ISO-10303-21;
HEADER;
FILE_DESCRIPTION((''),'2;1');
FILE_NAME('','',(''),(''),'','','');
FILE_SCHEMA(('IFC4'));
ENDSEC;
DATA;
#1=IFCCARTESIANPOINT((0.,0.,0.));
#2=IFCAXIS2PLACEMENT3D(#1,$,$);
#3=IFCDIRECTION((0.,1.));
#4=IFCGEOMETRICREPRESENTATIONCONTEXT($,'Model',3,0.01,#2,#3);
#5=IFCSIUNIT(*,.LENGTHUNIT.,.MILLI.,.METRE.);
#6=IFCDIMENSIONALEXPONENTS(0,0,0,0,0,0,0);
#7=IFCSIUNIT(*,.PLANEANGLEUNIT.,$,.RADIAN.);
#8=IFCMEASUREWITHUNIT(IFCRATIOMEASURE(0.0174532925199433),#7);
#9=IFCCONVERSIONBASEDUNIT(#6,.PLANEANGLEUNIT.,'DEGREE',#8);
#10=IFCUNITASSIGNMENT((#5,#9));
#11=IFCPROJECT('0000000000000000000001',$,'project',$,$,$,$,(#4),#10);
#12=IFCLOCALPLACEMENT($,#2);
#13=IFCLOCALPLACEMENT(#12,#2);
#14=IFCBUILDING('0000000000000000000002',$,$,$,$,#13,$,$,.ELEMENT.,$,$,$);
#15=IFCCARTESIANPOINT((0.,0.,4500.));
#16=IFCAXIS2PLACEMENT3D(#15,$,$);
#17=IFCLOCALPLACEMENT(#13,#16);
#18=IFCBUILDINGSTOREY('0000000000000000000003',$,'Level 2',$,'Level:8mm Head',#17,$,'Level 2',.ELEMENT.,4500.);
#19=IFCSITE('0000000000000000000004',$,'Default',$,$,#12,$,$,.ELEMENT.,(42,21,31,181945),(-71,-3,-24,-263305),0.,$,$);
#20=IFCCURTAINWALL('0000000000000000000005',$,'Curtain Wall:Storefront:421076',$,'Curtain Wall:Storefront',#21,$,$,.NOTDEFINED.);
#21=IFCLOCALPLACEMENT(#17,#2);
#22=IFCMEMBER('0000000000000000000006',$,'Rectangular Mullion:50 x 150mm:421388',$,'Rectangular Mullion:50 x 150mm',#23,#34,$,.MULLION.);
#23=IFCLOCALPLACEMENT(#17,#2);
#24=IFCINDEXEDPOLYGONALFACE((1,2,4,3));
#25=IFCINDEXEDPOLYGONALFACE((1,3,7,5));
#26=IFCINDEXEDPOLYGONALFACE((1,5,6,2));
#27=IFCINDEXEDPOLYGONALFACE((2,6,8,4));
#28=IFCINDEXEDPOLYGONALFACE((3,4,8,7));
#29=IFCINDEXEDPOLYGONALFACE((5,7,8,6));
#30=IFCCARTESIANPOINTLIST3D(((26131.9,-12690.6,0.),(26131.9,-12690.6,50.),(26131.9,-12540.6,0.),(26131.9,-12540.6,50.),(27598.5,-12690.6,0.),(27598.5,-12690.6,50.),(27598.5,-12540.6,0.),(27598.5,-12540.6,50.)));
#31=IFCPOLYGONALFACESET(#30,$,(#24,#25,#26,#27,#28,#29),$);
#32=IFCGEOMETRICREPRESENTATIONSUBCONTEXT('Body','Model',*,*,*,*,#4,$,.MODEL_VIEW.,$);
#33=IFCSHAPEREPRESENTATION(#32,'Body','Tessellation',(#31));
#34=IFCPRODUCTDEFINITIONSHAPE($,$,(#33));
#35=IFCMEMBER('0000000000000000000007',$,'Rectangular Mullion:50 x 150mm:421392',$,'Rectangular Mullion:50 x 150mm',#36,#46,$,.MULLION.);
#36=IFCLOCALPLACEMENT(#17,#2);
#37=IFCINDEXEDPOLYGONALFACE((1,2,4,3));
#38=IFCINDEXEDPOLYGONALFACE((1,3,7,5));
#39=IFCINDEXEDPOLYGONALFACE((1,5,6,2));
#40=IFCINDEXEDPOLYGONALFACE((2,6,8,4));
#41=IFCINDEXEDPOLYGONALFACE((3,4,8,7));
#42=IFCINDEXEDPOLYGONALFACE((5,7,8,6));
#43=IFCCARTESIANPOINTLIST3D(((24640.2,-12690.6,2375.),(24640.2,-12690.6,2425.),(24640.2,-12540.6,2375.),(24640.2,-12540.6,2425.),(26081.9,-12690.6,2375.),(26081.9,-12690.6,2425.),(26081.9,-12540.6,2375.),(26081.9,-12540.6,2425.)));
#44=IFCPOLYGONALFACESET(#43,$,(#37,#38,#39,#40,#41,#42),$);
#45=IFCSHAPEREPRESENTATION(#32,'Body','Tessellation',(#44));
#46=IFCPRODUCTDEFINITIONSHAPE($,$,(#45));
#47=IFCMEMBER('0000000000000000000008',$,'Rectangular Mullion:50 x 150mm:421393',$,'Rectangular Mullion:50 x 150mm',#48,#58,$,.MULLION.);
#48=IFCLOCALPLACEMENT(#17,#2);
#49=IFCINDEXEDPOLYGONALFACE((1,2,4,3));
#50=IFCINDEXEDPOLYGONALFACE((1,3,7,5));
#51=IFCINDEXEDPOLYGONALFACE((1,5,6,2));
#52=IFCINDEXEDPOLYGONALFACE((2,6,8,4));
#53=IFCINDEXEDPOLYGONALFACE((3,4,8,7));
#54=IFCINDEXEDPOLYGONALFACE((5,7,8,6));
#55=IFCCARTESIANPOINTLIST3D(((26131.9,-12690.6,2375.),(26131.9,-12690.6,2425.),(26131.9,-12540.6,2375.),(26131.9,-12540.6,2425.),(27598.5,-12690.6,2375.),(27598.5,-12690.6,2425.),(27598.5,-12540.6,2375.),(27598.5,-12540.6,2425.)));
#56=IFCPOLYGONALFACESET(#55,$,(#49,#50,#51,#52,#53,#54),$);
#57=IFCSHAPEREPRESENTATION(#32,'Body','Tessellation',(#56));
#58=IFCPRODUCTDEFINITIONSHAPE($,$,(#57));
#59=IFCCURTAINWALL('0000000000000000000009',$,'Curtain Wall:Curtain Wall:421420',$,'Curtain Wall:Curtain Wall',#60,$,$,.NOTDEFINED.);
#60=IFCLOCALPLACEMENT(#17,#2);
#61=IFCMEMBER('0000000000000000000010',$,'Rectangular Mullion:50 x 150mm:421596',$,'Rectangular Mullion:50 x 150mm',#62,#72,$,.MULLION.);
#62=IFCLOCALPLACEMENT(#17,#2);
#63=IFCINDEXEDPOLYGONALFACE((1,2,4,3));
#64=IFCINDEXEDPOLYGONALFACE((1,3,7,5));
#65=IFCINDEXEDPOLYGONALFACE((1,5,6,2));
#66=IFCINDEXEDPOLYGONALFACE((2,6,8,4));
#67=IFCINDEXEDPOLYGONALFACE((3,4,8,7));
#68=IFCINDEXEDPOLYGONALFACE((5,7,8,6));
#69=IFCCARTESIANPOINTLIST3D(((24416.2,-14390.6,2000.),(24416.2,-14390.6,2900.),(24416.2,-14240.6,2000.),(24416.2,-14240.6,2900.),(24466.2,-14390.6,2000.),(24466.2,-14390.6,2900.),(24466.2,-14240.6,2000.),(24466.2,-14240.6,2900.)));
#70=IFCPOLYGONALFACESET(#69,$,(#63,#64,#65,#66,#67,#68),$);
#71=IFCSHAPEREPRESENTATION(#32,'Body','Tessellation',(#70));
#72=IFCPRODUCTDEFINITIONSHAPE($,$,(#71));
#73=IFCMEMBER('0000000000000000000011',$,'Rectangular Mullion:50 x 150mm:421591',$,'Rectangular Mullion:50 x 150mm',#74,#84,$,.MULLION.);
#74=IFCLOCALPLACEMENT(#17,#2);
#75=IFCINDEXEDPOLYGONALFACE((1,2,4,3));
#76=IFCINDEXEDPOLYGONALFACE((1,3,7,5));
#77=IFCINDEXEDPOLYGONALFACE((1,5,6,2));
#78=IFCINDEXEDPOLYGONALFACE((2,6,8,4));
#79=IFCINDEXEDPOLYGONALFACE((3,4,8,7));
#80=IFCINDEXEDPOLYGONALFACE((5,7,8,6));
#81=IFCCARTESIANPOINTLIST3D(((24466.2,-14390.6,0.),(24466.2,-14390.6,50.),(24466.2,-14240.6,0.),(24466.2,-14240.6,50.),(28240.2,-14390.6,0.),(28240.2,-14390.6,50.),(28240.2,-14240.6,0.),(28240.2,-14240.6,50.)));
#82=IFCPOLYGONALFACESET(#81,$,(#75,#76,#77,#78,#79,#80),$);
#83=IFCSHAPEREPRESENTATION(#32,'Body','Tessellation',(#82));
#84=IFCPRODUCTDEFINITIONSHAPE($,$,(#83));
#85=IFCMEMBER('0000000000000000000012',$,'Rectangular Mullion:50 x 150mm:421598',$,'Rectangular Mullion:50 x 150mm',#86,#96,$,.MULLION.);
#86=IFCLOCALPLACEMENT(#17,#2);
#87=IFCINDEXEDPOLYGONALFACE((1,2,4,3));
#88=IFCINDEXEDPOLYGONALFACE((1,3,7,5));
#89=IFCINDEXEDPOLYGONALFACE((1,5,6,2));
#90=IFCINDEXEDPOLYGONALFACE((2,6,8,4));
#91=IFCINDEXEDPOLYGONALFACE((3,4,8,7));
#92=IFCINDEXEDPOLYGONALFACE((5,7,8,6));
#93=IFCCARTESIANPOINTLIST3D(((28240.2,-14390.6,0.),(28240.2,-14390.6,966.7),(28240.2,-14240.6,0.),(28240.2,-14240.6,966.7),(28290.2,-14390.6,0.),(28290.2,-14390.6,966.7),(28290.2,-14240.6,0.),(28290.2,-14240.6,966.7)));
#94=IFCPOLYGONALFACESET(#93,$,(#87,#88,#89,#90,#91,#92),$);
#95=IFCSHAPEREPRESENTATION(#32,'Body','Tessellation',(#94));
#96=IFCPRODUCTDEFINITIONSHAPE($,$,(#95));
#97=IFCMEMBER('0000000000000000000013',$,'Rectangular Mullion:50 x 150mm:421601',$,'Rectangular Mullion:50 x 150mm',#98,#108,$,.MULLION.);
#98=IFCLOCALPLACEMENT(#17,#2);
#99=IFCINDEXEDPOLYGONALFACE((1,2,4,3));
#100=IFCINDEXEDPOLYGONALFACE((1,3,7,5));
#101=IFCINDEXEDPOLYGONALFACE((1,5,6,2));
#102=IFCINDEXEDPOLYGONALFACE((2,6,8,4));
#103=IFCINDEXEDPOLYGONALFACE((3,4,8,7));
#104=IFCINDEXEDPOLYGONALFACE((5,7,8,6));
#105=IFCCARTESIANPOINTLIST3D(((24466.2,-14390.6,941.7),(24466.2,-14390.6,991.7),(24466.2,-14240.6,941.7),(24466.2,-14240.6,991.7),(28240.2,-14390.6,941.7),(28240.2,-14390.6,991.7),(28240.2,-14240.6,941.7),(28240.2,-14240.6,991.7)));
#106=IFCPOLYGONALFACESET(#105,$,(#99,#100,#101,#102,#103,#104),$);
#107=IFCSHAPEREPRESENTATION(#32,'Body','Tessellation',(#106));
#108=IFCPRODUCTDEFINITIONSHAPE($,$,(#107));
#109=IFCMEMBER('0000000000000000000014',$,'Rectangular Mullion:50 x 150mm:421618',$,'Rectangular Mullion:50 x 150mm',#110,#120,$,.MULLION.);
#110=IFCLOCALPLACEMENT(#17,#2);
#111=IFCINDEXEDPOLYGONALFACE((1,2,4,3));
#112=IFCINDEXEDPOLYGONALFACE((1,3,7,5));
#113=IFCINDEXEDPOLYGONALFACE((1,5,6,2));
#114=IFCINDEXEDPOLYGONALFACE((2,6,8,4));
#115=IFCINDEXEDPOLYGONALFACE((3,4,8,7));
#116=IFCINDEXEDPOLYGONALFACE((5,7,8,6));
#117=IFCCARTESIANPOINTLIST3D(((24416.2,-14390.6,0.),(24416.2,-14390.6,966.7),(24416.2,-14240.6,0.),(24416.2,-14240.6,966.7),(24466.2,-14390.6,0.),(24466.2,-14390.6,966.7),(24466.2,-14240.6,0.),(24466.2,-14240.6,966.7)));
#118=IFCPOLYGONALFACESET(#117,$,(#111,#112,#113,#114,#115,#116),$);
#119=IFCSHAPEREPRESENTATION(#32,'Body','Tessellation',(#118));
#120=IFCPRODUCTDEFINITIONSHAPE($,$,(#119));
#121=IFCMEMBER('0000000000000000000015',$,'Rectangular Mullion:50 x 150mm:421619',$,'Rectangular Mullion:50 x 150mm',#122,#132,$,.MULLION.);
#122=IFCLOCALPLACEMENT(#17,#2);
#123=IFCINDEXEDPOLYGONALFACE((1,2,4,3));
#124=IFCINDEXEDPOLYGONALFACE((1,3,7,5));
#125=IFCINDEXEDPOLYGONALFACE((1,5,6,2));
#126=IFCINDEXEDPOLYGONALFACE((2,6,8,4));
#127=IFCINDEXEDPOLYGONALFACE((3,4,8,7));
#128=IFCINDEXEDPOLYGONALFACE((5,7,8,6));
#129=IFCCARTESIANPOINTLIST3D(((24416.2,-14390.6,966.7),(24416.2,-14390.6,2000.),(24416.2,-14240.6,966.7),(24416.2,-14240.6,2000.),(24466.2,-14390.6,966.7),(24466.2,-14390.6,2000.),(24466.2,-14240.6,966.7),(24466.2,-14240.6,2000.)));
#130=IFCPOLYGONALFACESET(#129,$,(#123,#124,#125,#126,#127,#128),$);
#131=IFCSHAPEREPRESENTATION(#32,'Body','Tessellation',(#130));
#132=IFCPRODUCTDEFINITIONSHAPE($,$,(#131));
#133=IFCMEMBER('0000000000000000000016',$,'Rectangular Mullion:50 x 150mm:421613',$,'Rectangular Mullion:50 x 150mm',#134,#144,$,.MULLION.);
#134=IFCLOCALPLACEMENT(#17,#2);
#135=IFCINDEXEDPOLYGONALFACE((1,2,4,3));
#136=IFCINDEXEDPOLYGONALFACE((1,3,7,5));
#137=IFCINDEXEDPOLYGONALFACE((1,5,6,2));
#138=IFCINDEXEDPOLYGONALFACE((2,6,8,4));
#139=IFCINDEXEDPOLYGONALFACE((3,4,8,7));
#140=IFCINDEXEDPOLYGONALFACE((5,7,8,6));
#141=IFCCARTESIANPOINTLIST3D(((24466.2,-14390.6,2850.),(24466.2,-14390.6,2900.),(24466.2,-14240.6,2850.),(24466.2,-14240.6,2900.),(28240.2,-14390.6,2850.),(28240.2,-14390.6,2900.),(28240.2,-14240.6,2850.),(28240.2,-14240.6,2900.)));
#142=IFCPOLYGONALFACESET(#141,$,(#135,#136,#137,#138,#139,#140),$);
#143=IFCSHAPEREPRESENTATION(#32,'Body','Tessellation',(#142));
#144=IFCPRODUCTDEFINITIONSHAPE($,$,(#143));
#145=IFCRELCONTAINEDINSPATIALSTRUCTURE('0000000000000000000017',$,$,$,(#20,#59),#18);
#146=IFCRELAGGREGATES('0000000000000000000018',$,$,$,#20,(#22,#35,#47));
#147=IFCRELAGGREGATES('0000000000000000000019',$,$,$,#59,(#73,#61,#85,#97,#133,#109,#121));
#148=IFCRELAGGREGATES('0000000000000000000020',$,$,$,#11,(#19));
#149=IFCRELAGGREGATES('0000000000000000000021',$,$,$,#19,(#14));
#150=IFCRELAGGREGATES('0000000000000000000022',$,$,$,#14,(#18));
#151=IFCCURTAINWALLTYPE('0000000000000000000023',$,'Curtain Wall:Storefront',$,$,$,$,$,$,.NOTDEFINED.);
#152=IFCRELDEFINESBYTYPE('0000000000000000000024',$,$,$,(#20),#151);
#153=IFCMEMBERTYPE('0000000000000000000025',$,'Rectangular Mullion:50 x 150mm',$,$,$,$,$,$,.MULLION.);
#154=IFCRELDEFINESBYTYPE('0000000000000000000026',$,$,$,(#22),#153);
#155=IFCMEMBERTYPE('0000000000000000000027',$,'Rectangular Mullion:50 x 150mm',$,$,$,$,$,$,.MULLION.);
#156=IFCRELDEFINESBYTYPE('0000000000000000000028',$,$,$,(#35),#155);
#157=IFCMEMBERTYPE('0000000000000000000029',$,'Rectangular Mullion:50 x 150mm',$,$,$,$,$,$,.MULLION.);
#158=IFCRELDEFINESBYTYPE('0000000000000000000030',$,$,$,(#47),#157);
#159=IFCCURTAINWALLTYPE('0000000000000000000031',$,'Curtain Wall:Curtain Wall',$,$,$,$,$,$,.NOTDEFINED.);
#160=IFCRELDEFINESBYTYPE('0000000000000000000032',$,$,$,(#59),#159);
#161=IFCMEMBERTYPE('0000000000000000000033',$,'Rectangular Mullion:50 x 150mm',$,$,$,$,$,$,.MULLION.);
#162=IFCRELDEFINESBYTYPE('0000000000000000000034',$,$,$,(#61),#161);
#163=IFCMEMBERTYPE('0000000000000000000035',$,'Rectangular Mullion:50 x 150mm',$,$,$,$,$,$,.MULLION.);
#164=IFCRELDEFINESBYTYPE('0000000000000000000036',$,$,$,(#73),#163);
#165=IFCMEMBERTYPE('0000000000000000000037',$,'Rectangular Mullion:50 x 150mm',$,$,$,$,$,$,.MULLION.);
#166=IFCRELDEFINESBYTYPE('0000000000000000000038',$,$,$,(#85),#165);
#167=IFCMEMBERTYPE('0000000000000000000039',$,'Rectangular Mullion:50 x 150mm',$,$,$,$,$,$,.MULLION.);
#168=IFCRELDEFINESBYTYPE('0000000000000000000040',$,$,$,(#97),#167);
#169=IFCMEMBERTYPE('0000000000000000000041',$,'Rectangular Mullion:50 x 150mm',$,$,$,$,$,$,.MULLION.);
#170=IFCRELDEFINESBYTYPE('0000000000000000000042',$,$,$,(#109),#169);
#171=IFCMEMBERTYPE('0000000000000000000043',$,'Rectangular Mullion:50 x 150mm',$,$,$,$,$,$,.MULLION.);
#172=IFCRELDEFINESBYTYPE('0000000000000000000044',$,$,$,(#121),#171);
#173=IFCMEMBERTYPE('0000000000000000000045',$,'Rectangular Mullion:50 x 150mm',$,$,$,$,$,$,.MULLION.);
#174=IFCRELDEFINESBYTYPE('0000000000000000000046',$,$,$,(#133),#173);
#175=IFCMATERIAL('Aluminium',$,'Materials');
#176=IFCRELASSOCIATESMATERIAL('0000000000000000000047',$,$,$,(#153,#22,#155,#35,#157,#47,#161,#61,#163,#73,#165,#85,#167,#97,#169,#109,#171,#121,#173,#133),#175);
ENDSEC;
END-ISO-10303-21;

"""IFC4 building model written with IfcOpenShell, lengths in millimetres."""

from ifc_helpers import new_model, entity, si_unit, converted_unit, direction, frame, origin, place, context, subcontext, project, spatial, indexed_curve, outline, extrude, source, transform, mapped, material, type_object, type_shapes, element, aggregate, save


model = new_model("IFC4")

# Units and contexts
model_context = context("Model", 3, precision=0.01, world=origin(), true_north=direction((0.0, 1.0)))
body_context = subcontext(model_context, "Body", "Model", "MODEL_VIEW")
ifc_project = project(units=[si_unit("LENGTHUNIT", "METRE", prefix="MILLI"), converted_unit("PLANEANGLEUNIT", "DEGREE", entity("IfcRatioMeasure", 0.0174532925199433), si_unit("PLANEANGLEUNIT", "RADIAN"), dimensions=[0, 0, 0, 0, 0, 0, 0])], contexts=[model_context])

# Site, building, storey
site_placement = place(None, origin())
site = spatial("IfcSite", under=ifc_project, at=site_placement, Name="Default", CompositionType="ELEMENT", RefLatitude=(42, 21, 31, 181945), RefLongitude=(-71, -3, -24, -263305), RefElevation=0.0)
building_placement = place(site_placement, origin())
building = spatial("IfcBuilding", under=site, at=building_placement, CompositionType="ELEMENT")
storey_placement = place(building_placement, frame((0.0, 0.0, 4500.0)))
storey = spatial("IfcBuildingStorey", under=building, at=storey_placement, Name="Level 2", ObjectType="Level:8mm Head", LongName="Level 2", CompositionType="ELEMENT", Elevation=4500.0)

# Curtain walls, members
curtain_wall_type_1 = type_object("IfcCurtainWallType", Name="Curtain Wall:Storefront", PredefinedType="NOTDEFINED")
curtain_wall_1_placement = place(storey_placement, frame((0.0, 0.0, -4500.0)))
curtain_wall_1 = element("IfcCurtainWall", 1, at=curtain_wall_1_placement, inside=storey, type_object=curtain_wall_type_1, Name="Curtain Wall:Storefront:421076", ObjectType="Curtain Wall:Storefront", PredefinedType="NOTDEFINED")
ifc_material_1 = material(Name="Aluminium", Category="Materials")
member_type_1 = type_object("IfcMemberType", Name="Rectangular Mullion:50 x 150mm", PredefinedType="MULLION", material=ifc_material_1)
shared_shape_1 = source(origin(), body_context, "Body", "SweptSolid", [
    extrude(outline(indexed_curve([(-75.0, -25.0), (75.0, -25.0), (75.0, 25.0), (-75.0, 25.0), (-75.0, -25.0)], self_intersect=False)), frame((-25.0, 0.0, -1466.7), z_axis=(0.0, 0.0, 1.0), x_axis=(0.0, -1.0, 0.0)), (0.0, 0.0, 1.0), 1466.7),
])
type_shapes(member_type_1, [shared_shape_1])
member_1_placement = place(storey_placement, frame((26131.9, -12615.6, 0.0), z_axis=(-1.0, 0.0, 0.0), x_axis=(0.0, 0.0, -1.0)))
member_1 = element("IfcMember", 2, at=member_1_placement, type_object=member_type_1, material=ifc_material_1, Name="Rectangular Mullion:50 x 150mm:421388", ObjectType="Rectangular Mullion:50 x 150mm", PredefinedType="MULLION", context=body_context, shape_type="MappedRepresentation", body=[
    mapped(shared_shape_1, transform((0.0, 0.0, 0.0), scale=1.0)),
])
member_type_2 = type_object("IfcMemberType", Name="Rectangular Mullion:50 x 150mm", PredefinedType="MULLION", material=ifc_material_1)
shared_shape_2 = source(origin(), body_context, "Body", "SweptSolid", [
    extrude(outline(indexed_curve([(-75.0, -25.0), (75.0, -25.0), (75.0, 25.0), (-75.0, 25.0), (-75.0, -25.0)], self_intersect=False)), frame((0.0, 0.0, -1441.7), z_axis=(0.0, 0.0, 1.0), x_axis=(0.0, -1.0, 0.0)), (0.0, 0.0, 1.0), 1441.7),
])
type_shapes(member_type_2, [shared_shape_2])
member_2_placement = place(storey_placement, frame((26081.9, -12615.6, 2400.0), z_axis=(1.0, 0.0, 0.0), x_axis=(0.0, 0.0, 1.0)))
member_2 = element("IfcMember", 3, at=member_2_placement, type_object=member_type_2, material=ifc_material_1, Name="Rectangular Mullion:50 x 150mm:421392", ObjectType="Rectangular Mullion:50 x 150mm", PredefinedType="MULLION", context=body_context, shape_type="MappedRepresentation", body=[
    mapped(shared_shape_2, transform((0.0, 0.0, 0.0), scale=1.0)),
])
member_type_3 = type_object("IfcMemberType", Name="Rectangular Mullion:50 x 150mm", PredefinedType="MULLION", material=ifc_material_1)
shared_shape_3 = source(origin(), body_context, "Body", "SweptSolid", [
    extrude(outline(indexed_curve([(-75.0, -25.0), (75.0, -25.0), (75.0, 25.0), (-75.0, 25.0), (-75.0, -25.0)], self_intersect=False)), frame((0.0, 0.0, -1466.7), z_axis=(0.0, 0.0, 1.0), x_axis=(0.0, -1.0, 0.0)), (0.0, 0.0, 1.0), 1466.7),
])
type_shapes(member_type_3, [shared_shape_3])
member_3_placement = place(storey_placement, frame((27598.5, -12615.6, 2400.0), z_axis=(1.0, 0.0, 0.0), x_axis=(0.0, 0.0, 1.0)))
member_3 = element("IfcMember", 4, at=member_3_placement, type_object=member_type_3, material=ifc_material_1, Name="Rectangular Mullion:50 x 150mm:421393", ObjectType="Rectangular Mullion:50 x 150mm", PredefinedType="MULLION", context=body_context, shape_type="MappedRepresentation", body=[
    mapped(shared_shape_3, transform((0.0, 0.0, 0.0), scale=1.0)),
])
curtain_wall_type_2 = type_object("IfcCurtainWallType", Name="Curtain Wall:Curtain Wall", PredefinedType="NOTDEFINED")
curtain_wall_2_placement = place(storey_placement, frame((0.0, 0.0, -4500.0)))
curtain_wall_2 = element("IfcCurtainWall", 5, at=curtain_wall_2_placement, inside=storey, type_object=curtain_wall_type_2, Name="Curtain Wall:Curtain Wall:421420", ObjectType="Curtain Wall:Curtain Wall", PredefinedType="NOTDEFINED")
member_type_4 = type_object("IfcMemberType", Name="Rectangular Mullion:50 x 150mm", PredefinedType="MULLION", material=ifc_material_1)
shared_shape_4 = source(origin(), body_context, "Body", "SweptSolid", [
    extrude(outline(indexed_curve([(-75.0, -25.0), (75.0, -25.0), (75.0, 25.0), (-75.0, 25.0), (-75.0, -25.0)], self_intersect=False)), frame((-25.0, 0.0, -900.0), z_axis=(0.0, 0.0, 1.0), x_axis=(0.0, -1.0, 0.0)), (0.0, 0.0, 1.0), 900.0),
])
type_shapes(member_type_4, [shared_shape_4])
member_4_placement = place(storey_placement, frame((24416.2, -14315.6, 2900.0), z_axis=(0.0, 0.0, 1.0), x_axis=(-1.0, 0.0, 0.0)))
member_4 = element("IfcMember", 6, at=member_4_placement, type_object=member_type_4, material=ifc_material_1, Name="Rectangular Mullion:50 x 150mm:421596", ObjectType="Rectangular Mullion:50 x 150mm", PredefinedType="MULLION", context=body_context, shape_type="MappedRepresentation", body=[
    mapped(shared_shape_4, transform((0.0, 0.0, 0.0), scale=1.0)),
])
member_type_5 = type_object("IfcMemberType", Name="Rectangular Mullion:50 x 150mm", PredefinedType="MULLION", material=ifc_material_1)
shared_shape_5 = source(origin(), body_context, "Body", "SweptSolid", [
    extrude(outline(indexed_curve([(-75.0, -25.0), (75.0, -25.0), (75.0, 25.0), (-75.0, 25.0), (-75.0, -25.0)], self_intersect=False)), frame((-25.0, 0.0, -3774.0), z_axis=(0.0, 0.0, 1.0), x_axis=(0.0, -1.0, 0.0)), (0.0, 0.0, 1.0), 3774.0),
])
type_shapes(member_type_5, [shared_shape_5])
member_5_placement = place(storey_placement, frame((24466.2, -14315.6, 0.0), z_axis=(-1.0, 0.0, 0.0), x_axis=(0.0, 0.0, -1.0)))
member_5 = element("IfcMember", 7, at=member_5_placement, type_object=member_type_5, material=ifc_material_1, Name="Rectangular Mullion:50 x 150mm:421591", ObjectType="Rectangular Mullion:50 x 150mm", PredefinedType="MULLION", context=body_context, shape_type="MappedRepresentation", body=[
    mapped(shared_shape_5, transform((0.0, 0.0, 0.0), scale=1.0)),
])
member_type_6 = type_object("IfcMemberType", Name="Rectangular Mullion:50 x 150mm", PredefinedType="MULLION", material=ifc_material_1)
shared_shape_6 = source(origin(), body_context, "Body", "SweptSolid", [
    extrude(outline(indexed_curve([(-75.0, -25.0), (75.0, -25.0), (75.0, 25.0), (-75.0, 25.0), (-75.0, -25.0)], self_intersect=False)), frame((0.0, 0.0, -966.7), z_axis=(0.0, 0.0, 1.0), x_axis=(0.0, -1.0, 0.0)), (0.0, 0.0, 1.0), 966.7),
])
type_shapes(member_type_6, [shared_shape_6])
member_6_placement = place(storey_placement, frame((28265.2, -14315.6, 0.0), z_axis=(0.0, 0.0, -1.0), x_axis=(1.0, 0.0, 0.0)))
member_6 = element("IfcMember", 8, at=member_6_placement, type_object=member_type_6, material=ifc_material_1, Name="Rectangular Mullion:50 x 150mm:421598", ObjectType="Rectangular Mullion:50 x 150mm", PredefinedType="MULLION", context=body_context, shape_type="MappedRepresentation", body=[
    mapped(shared_shape_6, transform((0.0, 0.0, 0.0), scale=1.0)),
])
member_type_7 = type_object("IfcMemberType", Name="Rectangular Mullion:50 x 150mm", PredefinedType="MULLION", material=ifc_material_1)
shared_shape_7 = source(origin(), body_context, "Body", "SweptSolid", [
    extrude(outline(indexed_curve([(-75.0, -25.0), (75.0, -25.0), (75.0, 25.0), (-75.0, 25.0), (-75.0, -25.0)], self_intersect=False)), frame((0.0, 0.0, -3774.0), z_axis=(0.0, 0.0, 1.0), x_axis=(0.0, -1.0, 0.0)), (0.0, 0.0, 1.0), 3774.0),
])
type_shapes(member_type_7, [shared_shape_7])
member_7_placement = place(storey_placement, frame((28240.2, -14315.6, 966.7), z_axis=(1.0, 0.0, 0.0), x_axis=(0.0, 0.0, 1.0)))
member_7 = element("IfcMember", 9, at=member_7_placement, type_object=member_type_7, material=ifc_material_1, Name="Rectangular Mullion:50 x 150mm:421601", ObjectType="Rectangular Mullion:50 x 150mm", PredefinedType="MULLION", context=body_context, shape_type="MappedRepresentation", body=[
    mapped(shared_shape_7, transform((0.0, 0.0, 0.0), scale=1.0)),
])
member_type_8 = type_object("IfcMemberType", Name="Rectangular Mullion:50 x 150mm", PredefinedType="MULLION", material=ifc_material_1)
shared_shape_8 = source(origin(), body_context, "Body", "SweptSolid", [
    extrude(outline(indexed_curve([(-75.0, -25.0), (75.0, -25.0), (75.0, 25.0), (-75.0, 25.0), (-75.0, -25.0)], self_intersect=False)), frame((-25.0, 0.0, -966.7), z_axis=(0.0, 0.0, 1.0), x_axis=(0.0, -1.0, 0.0)), (0.0, 0.0, 1.0), 966.7),
])
type_shapes(member_type_8, [shared_shape_8])
member_8_placement = place(storey_placement, frame((24416.2, -14315.6, 966.7), z_axis=(0.0, 0.0, 1.0), x_axis=(-1.0, 0.0, 0.0)))
member_8 = element("IfcMember", 10, at=member_8_placement, type_object=member_type_8, material=ifc_material_1, Name="Rectangular Mullion:50 x 150mm:421618", ObjectType="Rectangular Mullion:50 x 150mm", PredefinedType="MULLION", context=body_context, shape_type="MappedRepresentation", body=[
    mapped(shared_shape_8, transform((0.0, 0.0, 0.0), scale=1.0)),
])
member_type_9 = type_object("IfcMemberType", Name="Rectangular Mullion:50 x 150mm", PredefinedType="MULLION", material=ifc_material_1)
shared_shape_9 = source(origin(), body_context, "Body", "SweptSolid", [
    extrude(outline(indexed_curve([(-75.0, -25.0), (75.0, -25.0), (75.0, 25.0), (-75.0, 25.0), (-75.0, -25.0)], self_intersect=False)), frame((-25.0, 0.0, -1033.3), z_axis=(0.0, 0.0, 1.0), x_axis=(0.0, -1.0, 0.0)), (0.0, 0.0, 1.0), 1033.3),
])
type_shapes(member_type_9, [shared_shape_9])
member_9_placement = place(storey_placement, frame((24416.2, -14315.6, 2000.0), z_axis=(0.0, 0.0, 1.0), x_axis=(-1.0, 0.0, 0.0)))
member_9 = element("IfcMember", 11, at=member_9_placement, type_object=member_type_9, material=ifc_material_1, Name="Rectangular Mullion:50 x 150mm:421619", ObjectType="Rectangular Mullion:50 x 150mm", PredefinedType="MULLION", context=body_context, shape_type="MappedRepresentation", body=[
    mapped(shared_shape_9, transform((0.0, 0.0, 0.0), scale=1.0)),
])
member_type_10 = type_object("IfcMemberType", Name="Rectangular Mullion:50 x 150mm", PredefinedType="MULLION", material=ifc_material_1)
shared_shape_10 = source(origin(), body_context, "Body", "SweptSolid", [
    extrude(outline(indexed_curve([(-75.0, -25.0), (75.0, -25.0), (75.0, 25.0), (-75.0, 25.0), (-75.0, -25.0)], self_intersect=False)), frame((-25.0, 0.0, -3774.0), z_axis=(0.0, 0.0, 1.0), x_axis=(0.0, -1.0, 0.0)), (0.0, 0.0, 1.0), 3774.0),
])
type_shapes(member_type_10, [shared_shape_10])
member_10_placement = place(storey_placement, frame((28240.2, -14315.6, 2900.0), z_axis=(1.0, 0.0, 0.0), x_axis=(0.0, 0.0, 1.0)))
member_10 = element("IfcMember", 12, at=member_10_placement, type_object=member_type_10, material=ifc_material_1, Name="Rectangular Mullion:50 x 150mm:421613", ObjectType="Rectangular Mullion:50 x 150mm", PredefinedType="MULLION", context=body_context, shape_type="MappedRepresentation", body=[
    mapped(shared_shape_10, transform((0.0, 0.0, 0.0), scale=1.0)),
])

aggregate(curtain_wall_1, [member_1, member_2, member_3])

aggregate(curtain_wall_2, [member_5, member_4, member_6, member_7, member_10, member_8, member_9])

save(model, "model.ifc")
